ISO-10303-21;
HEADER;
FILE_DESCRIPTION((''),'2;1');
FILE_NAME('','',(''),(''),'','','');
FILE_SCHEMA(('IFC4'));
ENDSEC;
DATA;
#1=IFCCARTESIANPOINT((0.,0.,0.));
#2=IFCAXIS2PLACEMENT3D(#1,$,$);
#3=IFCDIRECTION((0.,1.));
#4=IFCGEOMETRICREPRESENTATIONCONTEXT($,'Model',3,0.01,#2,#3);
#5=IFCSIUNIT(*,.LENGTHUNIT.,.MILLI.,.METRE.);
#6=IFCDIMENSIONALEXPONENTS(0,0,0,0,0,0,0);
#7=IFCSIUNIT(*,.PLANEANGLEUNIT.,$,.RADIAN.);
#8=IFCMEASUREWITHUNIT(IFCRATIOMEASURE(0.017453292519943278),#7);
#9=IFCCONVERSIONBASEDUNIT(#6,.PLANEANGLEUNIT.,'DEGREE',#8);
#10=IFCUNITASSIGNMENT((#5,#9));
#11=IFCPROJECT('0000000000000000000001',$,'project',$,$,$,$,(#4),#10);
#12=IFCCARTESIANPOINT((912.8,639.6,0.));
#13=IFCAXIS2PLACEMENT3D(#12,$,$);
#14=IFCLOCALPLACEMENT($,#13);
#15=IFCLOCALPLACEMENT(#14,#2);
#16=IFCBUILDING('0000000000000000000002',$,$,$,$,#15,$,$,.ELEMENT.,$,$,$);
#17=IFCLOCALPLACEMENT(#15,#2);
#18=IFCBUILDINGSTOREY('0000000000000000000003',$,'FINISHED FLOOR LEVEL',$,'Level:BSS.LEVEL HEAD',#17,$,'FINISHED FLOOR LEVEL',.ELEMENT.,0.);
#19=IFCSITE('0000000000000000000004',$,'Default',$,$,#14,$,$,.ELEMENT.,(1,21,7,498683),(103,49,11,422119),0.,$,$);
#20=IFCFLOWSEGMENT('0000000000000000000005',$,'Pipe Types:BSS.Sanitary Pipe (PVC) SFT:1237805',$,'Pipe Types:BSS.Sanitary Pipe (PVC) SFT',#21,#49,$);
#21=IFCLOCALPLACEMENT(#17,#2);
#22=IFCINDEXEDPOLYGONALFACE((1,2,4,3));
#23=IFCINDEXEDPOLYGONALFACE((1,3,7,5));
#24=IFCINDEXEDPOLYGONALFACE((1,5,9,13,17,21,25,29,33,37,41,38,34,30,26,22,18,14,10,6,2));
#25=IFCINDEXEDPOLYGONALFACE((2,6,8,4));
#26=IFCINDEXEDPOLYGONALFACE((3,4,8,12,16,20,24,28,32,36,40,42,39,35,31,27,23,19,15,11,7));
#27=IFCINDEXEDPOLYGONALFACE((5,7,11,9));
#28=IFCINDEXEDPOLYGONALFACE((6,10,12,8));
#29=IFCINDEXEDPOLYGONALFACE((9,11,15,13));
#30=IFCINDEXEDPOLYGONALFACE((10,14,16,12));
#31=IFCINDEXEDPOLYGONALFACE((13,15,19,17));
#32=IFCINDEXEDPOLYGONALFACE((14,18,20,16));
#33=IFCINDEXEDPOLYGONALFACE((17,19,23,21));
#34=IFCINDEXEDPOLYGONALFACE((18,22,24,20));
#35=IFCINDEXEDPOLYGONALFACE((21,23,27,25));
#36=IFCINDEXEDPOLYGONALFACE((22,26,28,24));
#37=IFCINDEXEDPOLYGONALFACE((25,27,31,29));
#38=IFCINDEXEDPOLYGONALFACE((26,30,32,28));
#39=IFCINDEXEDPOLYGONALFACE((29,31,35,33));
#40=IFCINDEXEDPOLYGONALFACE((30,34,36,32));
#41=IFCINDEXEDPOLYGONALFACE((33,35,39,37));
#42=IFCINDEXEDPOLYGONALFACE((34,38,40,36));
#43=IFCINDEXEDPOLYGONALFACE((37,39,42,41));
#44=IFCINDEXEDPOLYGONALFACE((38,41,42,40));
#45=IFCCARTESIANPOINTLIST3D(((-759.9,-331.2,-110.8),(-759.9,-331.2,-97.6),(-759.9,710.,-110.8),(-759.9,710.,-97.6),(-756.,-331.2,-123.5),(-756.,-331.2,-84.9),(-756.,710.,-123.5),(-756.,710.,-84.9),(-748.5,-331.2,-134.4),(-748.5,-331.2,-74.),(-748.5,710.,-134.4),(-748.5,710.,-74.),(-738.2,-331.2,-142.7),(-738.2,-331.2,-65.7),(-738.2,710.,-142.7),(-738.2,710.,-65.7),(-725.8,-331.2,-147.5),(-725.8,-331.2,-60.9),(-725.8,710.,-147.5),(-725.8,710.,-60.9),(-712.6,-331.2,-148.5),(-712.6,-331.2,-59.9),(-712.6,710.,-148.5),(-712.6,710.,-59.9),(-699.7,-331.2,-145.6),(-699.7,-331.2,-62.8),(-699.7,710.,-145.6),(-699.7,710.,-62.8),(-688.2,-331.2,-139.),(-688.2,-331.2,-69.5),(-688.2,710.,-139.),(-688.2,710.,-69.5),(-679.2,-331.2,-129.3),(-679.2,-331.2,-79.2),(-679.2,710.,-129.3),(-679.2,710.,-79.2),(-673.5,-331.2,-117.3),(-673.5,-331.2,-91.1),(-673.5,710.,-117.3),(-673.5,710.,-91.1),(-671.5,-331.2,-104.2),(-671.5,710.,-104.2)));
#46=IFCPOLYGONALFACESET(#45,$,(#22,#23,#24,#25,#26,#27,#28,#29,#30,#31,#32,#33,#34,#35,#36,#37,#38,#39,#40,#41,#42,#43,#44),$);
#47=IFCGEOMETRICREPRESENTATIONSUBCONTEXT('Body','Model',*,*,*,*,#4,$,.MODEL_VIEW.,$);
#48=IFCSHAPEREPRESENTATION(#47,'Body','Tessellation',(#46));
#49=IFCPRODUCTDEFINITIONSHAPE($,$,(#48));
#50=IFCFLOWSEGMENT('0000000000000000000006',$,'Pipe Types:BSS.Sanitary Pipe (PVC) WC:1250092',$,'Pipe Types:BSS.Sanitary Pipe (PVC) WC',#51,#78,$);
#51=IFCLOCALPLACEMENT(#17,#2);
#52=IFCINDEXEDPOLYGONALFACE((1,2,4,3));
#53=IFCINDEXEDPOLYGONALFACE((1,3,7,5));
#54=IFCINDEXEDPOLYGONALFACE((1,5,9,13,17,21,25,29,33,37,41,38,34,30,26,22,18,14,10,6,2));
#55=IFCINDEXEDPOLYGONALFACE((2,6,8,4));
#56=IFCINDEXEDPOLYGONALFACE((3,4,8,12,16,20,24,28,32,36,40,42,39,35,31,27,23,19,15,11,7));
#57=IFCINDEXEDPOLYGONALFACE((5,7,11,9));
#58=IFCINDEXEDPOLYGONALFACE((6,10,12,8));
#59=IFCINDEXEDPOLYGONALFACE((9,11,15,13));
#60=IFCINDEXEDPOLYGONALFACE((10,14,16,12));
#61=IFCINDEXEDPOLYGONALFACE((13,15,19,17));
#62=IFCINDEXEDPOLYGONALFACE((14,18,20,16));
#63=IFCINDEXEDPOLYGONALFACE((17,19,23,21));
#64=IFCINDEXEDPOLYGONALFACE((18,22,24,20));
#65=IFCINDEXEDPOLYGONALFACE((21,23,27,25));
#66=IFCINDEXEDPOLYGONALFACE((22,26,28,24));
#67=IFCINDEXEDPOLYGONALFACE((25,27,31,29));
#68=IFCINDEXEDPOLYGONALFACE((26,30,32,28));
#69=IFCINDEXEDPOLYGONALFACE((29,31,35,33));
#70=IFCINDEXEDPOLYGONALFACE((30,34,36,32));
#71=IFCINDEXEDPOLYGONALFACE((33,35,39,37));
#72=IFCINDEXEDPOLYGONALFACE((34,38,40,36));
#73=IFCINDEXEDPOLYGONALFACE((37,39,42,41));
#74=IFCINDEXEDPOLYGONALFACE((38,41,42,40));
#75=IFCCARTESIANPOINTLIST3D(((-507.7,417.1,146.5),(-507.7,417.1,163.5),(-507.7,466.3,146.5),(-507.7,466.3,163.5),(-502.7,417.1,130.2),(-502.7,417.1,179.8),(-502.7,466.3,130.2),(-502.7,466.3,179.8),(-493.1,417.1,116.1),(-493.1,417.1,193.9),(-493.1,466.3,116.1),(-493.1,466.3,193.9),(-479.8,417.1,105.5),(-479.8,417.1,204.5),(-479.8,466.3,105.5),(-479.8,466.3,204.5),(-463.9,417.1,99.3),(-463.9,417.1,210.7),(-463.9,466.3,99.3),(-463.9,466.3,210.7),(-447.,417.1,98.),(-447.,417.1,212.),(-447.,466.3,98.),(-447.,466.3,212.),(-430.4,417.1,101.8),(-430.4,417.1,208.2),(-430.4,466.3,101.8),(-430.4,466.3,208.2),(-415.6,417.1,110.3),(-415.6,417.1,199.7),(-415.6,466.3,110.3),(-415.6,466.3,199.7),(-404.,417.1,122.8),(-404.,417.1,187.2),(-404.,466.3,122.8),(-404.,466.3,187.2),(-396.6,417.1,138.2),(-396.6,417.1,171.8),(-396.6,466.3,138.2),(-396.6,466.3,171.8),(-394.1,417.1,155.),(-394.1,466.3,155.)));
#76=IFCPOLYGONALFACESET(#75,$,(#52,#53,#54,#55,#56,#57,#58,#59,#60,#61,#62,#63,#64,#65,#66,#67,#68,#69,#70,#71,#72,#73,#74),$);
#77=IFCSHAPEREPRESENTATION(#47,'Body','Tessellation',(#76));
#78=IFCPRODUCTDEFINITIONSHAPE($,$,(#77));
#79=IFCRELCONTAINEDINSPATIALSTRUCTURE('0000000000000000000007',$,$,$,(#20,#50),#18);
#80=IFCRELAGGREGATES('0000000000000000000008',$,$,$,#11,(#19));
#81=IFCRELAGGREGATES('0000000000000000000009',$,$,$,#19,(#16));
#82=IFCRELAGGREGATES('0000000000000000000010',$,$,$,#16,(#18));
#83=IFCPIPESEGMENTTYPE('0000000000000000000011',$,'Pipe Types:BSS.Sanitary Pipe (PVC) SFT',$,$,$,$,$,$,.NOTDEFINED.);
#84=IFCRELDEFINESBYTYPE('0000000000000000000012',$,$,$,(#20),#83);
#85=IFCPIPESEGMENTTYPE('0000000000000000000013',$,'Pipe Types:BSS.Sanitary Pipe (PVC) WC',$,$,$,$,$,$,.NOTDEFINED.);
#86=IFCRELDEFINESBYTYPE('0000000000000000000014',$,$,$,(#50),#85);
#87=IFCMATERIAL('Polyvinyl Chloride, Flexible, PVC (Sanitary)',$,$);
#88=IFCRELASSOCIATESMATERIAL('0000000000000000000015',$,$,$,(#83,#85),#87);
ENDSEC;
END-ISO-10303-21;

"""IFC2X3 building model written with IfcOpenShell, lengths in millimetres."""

from ifc_helpers import new_model, entity, si_unit, converted_unit, direction, frame, frame_2d, origin, place, context, subcontext, project, spatial, circle, extrude, material, type_object, element, save


model = new_model("IFC2X3")

# Units and contexts
model_context = context("Model", 3, precision=0.01, world=origin(), true_north=direction((0.0, 1.0)))
body_context = subcontext(model_context, "Body", "Model", "MODEL_VIEW")
ifc_project = project(units=[si_unit("LENGTHUNIT", "METRE", prefix="MILLI"), converted_unit("PLANEANGLEUNIT", "DEGREE", entity("IfcRatioMeasure", 0.017453292519943278), si_unit("PLANEANGLEUNIT", "RADIAN"), dimensions=[0, 0, 0, 0, 0, 0, 0])], contexts=[model_context])

# Site, building, storey
site_placement = place(None, frame((912.8, 639.6, 0.0)))
site = spatial("IfcSite", under=ifc_project, at=site_placement, Name="Default", CompositionType="ELEMENT", RefLatitude=(1, 21, 7, 498683), RefLongitude=(103, 49, 11, 422119), RefElevation=0.0)
building_placement = place(site_placement, origin())
building = spatial("IfcBuilding", under=site, at=building_placement, CompositionType="ELEMENT")
storey_placement = place(building_placement, origin())
storey = spatial("IfcBuildingStorey", under=building, at=storey_placement, Name="FINISHED FLOOR LEVEL", ObjectType="Level:BSS.LEVEL HEAD", LongName="FINISHED FLOOR LEVEL", CompositionType="ELEMENT", Elevation=0.0)

# Flow segments
ifc_material_1 = material(Name="Polyvinyl Chloride, Flexible, PVC (Sanitary)")
pipe_segment_type_1 = type_object("IfcPipeSegmentType", Name="Pipe Types:BSS.Sanitary Pipe (PVC) SFT", PredefinedType="NOTDEFINED", material=ifc_material_1)
flow_segment_1_placement = place(storey_placement, origin())
element("IfcFlowSegment", 1, at=flow_segment_1_placement, inside=storey, type_object=pipe_segment_type_1, Name="Pipe Types:BSS.Sanitary Pipe (PVC) SFT:1237805", ObjectType="Pipe Types:BSS.Sanitary Pipe (PVC) SFT", context=body_context, shape_type="SweptSolid", body=[
    extrude(circle(Radius=44.5, at=frame_2d((0.0, 0.0), x_axis=(1.0, 0.0))), frame((-715.9, -331.2, -104.2), z_axis=(0.0, 1.0, 0.0), x_axis=(1.0, 0.0, 0.0)), (0.0, 0.0, 1.0), 1041.2),
])
pipe_segment_type_2 = type_object("IfcPipeSegmentType", Name="Pipe Types:BSS.Sanitary Pipe (PVC) WC", PredefinedType="NOTDEFINED", material=ifc_material_1)
flow_segment_2_placement = place(storey_placement, origin())
element("IfcFlowSegment", 2, at=flow_segment_2_placement, inside=storey, type_object=pipe_segment_type_2, Name="Pipe Types:BSS.Sanitary Pipe (PVC) WC:1250092", ObjectType="Pipe Types:BSS.Sanitary Pipe (PVC) WC", context=body_context, shape_type="SweptSolid", body=[
    extrude(circle(Radius=57.2, at=frame_2d((0.0, 0.0), x_axis=(1.0, 0.0))), frame((-451.2, 417.1, 155.0), z_axis=(0.0, 1.0, 0.0), x_axis=(1.0, 0.0, 0.0)), (0.0, 0.0, 1.0), 49.2),
])

save(model, "model.ifc")
